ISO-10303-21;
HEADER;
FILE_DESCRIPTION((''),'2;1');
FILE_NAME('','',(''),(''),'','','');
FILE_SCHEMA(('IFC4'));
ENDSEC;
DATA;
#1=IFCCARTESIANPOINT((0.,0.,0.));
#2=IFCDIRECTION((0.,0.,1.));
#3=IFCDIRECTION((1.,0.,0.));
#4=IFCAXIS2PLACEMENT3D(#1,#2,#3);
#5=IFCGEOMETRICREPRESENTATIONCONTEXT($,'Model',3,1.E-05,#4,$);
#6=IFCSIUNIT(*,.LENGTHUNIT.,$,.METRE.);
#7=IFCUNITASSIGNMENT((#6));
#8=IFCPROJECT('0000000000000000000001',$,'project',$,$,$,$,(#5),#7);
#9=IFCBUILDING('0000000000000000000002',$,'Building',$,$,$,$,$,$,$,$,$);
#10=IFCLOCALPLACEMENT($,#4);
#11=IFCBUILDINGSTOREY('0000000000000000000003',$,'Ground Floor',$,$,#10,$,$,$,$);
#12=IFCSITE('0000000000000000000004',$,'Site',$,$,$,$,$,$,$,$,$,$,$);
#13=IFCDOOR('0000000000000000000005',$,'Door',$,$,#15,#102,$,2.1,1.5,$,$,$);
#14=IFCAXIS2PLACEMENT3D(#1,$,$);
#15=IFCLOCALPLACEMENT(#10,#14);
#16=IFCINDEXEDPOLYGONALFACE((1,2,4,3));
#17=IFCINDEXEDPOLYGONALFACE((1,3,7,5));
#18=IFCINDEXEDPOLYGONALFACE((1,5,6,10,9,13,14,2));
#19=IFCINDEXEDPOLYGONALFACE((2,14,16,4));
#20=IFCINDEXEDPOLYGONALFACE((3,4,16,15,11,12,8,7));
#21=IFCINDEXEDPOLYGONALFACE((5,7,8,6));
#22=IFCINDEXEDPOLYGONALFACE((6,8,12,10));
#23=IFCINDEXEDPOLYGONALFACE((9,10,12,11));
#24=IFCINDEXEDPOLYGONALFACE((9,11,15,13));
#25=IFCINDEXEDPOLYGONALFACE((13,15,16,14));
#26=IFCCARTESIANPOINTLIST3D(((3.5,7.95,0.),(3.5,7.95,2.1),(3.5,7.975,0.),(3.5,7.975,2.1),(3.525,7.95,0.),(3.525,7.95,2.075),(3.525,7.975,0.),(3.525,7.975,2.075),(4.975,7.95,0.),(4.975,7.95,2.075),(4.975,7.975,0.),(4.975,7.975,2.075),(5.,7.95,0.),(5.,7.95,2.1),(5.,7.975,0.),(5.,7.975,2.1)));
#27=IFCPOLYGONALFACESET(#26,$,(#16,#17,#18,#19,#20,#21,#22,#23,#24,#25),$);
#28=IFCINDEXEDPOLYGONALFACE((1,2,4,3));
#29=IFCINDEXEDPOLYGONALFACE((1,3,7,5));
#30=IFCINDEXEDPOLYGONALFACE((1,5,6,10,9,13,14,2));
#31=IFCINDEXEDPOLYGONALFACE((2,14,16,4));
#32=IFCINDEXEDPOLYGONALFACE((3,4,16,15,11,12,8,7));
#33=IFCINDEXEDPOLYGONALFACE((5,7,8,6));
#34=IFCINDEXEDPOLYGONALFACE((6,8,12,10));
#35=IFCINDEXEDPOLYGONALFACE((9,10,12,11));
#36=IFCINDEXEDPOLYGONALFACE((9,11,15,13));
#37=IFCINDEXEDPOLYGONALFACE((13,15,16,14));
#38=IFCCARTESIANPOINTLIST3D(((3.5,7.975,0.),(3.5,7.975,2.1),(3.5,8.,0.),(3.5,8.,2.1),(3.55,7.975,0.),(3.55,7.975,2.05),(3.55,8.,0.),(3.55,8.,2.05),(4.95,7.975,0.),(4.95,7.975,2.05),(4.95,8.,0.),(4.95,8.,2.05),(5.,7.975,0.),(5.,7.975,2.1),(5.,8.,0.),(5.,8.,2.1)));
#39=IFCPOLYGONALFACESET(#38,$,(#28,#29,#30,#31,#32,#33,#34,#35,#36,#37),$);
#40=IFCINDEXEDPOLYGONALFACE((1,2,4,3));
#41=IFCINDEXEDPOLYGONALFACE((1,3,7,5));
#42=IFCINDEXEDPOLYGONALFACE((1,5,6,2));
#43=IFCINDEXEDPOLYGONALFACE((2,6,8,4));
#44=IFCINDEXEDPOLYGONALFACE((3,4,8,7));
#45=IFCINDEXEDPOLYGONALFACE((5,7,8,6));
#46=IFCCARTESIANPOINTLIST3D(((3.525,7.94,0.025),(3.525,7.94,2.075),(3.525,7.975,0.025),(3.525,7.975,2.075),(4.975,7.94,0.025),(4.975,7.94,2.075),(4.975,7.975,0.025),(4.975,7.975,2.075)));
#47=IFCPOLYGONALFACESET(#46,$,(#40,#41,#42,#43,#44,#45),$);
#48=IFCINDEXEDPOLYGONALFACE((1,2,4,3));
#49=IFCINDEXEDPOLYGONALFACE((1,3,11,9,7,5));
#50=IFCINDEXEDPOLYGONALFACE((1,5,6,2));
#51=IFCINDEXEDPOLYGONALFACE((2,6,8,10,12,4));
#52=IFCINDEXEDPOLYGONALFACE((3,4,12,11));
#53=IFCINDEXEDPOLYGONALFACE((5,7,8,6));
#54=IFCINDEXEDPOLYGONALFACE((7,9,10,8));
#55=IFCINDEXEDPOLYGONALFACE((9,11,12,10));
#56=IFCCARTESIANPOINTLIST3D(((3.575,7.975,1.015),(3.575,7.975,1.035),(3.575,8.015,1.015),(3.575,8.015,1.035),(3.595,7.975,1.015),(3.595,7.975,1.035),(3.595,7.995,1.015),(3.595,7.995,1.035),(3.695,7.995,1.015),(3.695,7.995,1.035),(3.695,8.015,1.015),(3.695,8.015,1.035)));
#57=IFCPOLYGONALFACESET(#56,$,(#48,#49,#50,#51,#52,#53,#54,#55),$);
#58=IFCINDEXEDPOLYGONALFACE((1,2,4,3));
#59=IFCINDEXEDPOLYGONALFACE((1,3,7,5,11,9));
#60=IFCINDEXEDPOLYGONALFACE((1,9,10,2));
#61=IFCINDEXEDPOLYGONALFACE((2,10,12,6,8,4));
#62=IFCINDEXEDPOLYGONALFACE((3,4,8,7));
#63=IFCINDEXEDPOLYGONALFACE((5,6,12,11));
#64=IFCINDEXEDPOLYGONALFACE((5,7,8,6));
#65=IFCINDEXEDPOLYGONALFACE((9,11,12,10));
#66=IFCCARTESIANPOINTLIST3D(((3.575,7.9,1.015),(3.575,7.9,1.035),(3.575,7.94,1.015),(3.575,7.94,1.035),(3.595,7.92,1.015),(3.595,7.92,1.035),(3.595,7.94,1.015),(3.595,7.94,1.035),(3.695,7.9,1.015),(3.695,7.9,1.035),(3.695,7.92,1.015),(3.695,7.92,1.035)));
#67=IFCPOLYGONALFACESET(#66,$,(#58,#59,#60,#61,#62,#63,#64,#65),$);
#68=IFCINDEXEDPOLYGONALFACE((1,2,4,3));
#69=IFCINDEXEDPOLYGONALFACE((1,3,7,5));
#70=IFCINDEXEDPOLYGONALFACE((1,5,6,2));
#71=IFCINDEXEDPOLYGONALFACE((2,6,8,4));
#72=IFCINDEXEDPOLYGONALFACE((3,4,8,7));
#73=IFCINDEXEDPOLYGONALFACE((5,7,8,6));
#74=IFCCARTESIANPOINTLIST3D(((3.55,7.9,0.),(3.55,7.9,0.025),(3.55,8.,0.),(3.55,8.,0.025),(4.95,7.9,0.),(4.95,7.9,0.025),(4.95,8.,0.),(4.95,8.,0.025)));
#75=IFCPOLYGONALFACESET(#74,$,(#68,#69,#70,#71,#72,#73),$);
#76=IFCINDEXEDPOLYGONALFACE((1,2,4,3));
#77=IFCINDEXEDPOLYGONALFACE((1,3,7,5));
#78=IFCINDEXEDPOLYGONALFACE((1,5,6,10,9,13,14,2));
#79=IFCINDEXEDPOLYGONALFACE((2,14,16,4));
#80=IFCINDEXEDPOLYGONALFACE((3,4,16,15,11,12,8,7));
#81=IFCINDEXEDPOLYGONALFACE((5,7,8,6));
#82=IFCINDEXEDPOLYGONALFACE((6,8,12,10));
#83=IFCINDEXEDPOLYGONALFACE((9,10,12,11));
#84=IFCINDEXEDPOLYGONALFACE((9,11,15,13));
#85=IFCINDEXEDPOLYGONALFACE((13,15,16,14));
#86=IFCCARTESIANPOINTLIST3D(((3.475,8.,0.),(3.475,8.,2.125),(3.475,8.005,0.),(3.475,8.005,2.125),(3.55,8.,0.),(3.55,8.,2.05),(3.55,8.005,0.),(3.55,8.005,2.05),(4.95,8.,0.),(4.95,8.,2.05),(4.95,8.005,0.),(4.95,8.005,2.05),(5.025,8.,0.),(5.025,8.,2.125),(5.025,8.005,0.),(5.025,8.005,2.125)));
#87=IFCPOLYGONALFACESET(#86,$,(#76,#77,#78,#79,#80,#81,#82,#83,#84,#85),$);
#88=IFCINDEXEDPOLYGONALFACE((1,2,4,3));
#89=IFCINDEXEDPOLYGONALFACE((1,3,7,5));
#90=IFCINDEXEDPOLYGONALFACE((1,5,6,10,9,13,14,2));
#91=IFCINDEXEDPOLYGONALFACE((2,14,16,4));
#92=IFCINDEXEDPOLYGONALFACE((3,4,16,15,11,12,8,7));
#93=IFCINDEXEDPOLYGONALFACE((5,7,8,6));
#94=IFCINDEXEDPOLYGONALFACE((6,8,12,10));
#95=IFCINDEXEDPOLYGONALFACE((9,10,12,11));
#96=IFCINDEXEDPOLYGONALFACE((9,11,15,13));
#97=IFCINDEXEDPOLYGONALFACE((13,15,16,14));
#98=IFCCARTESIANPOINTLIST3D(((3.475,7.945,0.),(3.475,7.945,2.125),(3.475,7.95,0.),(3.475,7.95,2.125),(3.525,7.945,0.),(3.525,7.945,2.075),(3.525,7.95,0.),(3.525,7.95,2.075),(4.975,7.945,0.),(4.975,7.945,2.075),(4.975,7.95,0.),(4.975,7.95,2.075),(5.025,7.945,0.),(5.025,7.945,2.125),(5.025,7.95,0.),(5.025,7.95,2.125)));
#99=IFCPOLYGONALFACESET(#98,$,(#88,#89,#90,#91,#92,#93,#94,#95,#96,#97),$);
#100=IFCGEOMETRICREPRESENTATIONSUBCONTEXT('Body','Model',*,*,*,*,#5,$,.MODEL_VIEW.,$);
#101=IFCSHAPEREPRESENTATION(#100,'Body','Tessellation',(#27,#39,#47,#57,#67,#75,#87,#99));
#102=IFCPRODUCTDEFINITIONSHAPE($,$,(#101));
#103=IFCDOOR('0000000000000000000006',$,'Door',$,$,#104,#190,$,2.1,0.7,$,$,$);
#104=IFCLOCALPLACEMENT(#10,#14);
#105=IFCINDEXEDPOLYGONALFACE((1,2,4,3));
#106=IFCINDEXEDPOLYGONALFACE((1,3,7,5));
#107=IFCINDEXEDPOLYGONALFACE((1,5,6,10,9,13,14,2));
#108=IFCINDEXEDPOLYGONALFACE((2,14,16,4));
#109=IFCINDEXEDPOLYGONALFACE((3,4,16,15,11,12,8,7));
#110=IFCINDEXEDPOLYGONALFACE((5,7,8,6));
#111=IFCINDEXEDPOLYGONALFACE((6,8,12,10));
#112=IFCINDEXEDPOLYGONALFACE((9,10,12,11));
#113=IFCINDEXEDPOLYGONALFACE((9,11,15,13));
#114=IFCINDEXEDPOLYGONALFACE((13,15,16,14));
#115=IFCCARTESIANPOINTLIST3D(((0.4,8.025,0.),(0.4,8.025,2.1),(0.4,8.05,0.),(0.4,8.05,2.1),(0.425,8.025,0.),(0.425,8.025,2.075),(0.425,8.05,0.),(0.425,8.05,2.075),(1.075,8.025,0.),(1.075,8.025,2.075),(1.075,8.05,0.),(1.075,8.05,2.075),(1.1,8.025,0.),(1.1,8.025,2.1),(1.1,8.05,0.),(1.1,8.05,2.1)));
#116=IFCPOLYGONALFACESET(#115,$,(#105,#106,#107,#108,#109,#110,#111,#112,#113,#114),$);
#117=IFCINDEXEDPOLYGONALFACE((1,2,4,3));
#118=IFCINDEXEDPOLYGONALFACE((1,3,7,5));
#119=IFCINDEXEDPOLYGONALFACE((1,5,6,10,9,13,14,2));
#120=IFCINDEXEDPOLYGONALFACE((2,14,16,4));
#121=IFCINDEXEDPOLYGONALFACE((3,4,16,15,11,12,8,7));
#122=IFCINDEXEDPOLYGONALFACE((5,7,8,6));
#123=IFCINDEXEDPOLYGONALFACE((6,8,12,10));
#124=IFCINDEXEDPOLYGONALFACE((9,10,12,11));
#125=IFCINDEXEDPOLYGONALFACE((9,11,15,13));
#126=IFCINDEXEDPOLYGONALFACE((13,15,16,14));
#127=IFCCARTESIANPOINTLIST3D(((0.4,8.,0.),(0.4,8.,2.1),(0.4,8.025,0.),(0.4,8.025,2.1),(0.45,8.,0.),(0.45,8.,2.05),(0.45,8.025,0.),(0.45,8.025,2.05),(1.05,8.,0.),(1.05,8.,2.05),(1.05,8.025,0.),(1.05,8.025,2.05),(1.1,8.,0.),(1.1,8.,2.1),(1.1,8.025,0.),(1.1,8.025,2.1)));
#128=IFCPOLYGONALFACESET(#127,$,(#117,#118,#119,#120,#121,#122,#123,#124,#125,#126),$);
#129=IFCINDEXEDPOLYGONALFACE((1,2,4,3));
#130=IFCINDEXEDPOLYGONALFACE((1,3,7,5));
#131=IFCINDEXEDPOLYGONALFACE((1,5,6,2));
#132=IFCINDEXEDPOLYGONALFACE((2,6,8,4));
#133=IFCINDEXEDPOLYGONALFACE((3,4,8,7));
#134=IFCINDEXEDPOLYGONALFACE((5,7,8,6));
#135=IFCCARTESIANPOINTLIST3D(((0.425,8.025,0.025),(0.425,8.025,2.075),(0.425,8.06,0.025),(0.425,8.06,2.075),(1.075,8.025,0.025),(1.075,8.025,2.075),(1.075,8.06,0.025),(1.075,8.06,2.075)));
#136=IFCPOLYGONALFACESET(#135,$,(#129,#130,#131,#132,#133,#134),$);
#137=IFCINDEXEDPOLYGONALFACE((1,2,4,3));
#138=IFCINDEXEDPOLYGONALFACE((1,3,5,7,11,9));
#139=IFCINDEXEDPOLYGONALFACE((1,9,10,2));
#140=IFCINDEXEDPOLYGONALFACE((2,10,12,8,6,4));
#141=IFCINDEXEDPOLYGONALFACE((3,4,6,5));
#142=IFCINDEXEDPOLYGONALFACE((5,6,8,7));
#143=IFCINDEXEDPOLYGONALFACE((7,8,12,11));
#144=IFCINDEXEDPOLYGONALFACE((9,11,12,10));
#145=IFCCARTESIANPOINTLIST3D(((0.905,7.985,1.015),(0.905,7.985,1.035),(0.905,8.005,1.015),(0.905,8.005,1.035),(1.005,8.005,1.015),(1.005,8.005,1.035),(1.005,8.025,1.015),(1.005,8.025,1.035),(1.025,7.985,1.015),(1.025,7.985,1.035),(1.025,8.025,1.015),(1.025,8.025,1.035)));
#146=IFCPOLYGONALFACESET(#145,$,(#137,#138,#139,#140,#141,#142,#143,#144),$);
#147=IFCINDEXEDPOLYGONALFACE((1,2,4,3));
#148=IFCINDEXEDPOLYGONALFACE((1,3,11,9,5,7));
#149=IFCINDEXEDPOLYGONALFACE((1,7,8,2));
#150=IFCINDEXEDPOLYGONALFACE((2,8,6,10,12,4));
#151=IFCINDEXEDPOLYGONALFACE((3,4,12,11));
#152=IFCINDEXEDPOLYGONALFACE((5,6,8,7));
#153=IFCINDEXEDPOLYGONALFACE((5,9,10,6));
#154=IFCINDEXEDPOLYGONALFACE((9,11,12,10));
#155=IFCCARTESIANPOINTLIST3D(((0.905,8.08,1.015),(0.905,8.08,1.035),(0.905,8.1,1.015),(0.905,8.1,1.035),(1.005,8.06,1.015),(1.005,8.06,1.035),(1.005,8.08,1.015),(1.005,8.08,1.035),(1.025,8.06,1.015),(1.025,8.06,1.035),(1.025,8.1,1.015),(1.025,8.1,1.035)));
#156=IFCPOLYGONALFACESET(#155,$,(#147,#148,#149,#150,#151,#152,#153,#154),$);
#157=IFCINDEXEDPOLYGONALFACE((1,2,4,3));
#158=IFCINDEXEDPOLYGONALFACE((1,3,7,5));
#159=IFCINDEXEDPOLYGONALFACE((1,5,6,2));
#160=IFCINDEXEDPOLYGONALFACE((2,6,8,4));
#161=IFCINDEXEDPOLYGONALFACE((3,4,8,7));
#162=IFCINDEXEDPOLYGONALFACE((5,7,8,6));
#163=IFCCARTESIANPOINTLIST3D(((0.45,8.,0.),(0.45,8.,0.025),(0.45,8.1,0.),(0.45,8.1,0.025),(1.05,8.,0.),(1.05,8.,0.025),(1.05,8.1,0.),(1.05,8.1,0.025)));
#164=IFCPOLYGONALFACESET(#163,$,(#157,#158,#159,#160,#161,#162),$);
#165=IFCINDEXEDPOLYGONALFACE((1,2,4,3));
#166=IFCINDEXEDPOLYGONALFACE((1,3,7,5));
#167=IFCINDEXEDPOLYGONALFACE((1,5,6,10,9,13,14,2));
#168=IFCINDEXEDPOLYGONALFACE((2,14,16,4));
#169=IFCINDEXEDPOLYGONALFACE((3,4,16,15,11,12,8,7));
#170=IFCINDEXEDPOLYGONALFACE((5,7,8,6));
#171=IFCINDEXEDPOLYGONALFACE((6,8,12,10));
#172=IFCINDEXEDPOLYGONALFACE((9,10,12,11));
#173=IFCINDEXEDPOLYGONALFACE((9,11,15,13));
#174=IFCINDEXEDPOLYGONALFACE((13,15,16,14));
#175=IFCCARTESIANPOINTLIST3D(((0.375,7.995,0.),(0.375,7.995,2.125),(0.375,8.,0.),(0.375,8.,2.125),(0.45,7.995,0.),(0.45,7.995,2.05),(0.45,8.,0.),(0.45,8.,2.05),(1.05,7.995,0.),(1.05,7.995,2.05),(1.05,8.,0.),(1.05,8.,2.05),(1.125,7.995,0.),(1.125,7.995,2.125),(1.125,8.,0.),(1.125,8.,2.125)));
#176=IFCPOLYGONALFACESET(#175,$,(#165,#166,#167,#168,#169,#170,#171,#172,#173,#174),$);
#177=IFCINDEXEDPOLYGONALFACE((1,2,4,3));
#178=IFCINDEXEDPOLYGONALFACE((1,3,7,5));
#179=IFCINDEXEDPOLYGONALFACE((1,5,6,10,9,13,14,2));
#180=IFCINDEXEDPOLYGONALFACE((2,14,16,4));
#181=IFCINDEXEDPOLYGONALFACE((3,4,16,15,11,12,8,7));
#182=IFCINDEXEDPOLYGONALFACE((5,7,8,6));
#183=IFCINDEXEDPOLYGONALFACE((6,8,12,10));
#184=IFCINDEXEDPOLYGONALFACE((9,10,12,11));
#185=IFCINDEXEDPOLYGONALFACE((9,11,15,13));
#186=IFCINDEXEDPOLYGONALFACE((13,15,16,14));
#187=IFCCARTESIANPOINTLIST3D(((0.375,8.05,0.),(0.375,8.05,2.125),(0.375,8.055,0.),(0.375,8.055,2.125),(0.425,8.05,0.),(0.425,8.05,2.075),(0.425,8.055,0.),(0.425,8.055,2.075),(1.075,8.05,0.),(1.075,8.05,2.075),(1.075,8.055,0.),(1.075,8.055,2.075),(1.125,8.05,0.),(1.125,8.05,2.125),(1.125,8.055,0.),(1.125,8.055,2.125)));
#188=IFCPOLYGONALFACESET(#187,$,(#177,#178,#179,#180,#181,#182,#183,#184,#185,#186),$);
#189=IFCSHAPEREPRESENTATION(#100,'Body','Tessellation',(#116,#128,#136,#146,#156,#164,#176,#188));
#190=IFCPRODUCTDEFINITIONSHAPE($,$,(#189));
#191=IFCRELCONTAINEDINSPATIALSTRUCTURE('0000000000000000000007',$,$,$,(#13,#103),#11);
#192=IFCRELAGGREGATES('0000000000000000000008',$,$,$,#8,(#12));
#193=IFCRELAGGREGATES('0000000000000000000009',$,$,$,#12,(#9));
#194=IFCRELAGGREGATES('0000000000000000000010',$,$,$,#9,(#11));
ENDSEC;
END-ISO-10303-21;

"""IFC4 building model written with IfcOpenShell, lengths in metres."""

from ifc_helpers import new_model, si_unit, frame, origin_with_axes, place, context, subcontext, project, spatial, line, indexed_curve, outline, extrude, element, save


model = new_model("IFC4")

# Units and contexts
model_context = context("Model", 3, precision=1e-05, world=origin_with_axes())
body_context = subcontext(model_context, "Body", "Model", "MODEL_VIEW")
ifc_project = project(units=[si_unit("LENGTHUNIT", "METRE")], contexts=[model_context])

# Site, building, storey
site = spatial("IfcSite", under=ifc_project, Name="Site")
building = spatial("IfcBuilding", under=site, Name="Building")
storey_placement = place(None, origin_with_axes())
storey = spatial("IfcBuildingStorey", under=building, at=storey_placement, Name="Ground Floor")

# Doors
door_1_placement = place(storey_placement, frame((5.0, 8.0, 0.0), z_axis=(0.0, 0.0, 1.0), x_axis=(-1.0, 0.0, 0.0)))
element("IfcDoor", 1, at=door_1_placement, inside=storey, Name="Door", OverallHeight=2.1, OverallWidth=1.5, context=body_context, shape_type="SweptSolid", body=[
    extrude(outline(indexed_curve([(0.0, 0.0), (0.0, 2.1), (1.5, 2.1), (1.5, 0.0), (1.475, 0.0), (1.475, 2.075), (0.025, 2.075), (0.025, 0.0)], segments=[line(1, 2, 3, 4, 5, 6, 7, 8, 1)])), frame((0.0, 0.025, 0.0), z_axis=(0.0, -1.0, 0.0), x_axis=(1.0, 0.0, 0.0)), (0.0, 0.0, -1.0), 0.025),
    extrude(outline(indexed_curve([(0.0, 0.0), (0.0, 2.1), (1.5, 2.1), (1.5, 0.0), (1.45, 0.0), (1.45, 2.05), (0.05, 2.05), (0.05, 0.0)], segments=[line(1, 2, 3, 4, 5, 6, 7, 8, 1)])), frame((0.0, 0.0, 0.0), z_axis=(0.0, -1.0, 0.0), x_axis=(1.0, 0.0, 0.0)), (0.0, 0.0, -1.0), 0.025),
    extrude(outline(indexed_curve([(0.0, 0.0), (1.45, 0.0), (1.45, 0.035), (0.0, 0.035)], segments=[line(1, 2, 3, 4, 1)])), frame((0.025, 0.025, 0.025), z_axis=(0.0, 0.0, 1.0), x_axis=(1.0, 0.0, 0.0)), (0.0, 0.0, 1.0), 2.05),
    extrude(outline(indexed_curve([(0.0, 0.0), (0.0, -0.04), (-0.12, -0.04), (-0.12, -0.02), (-0.02, -0.02), (-0.02, 0.0)], segments=[line(1, 2, 3, 4, 5, 6, 1)])), frame((1.425, 0.025, 1.015), z_axis=(0.0, 0.0, 1.0), x_axis=(1.0, 0.0, 0.0)), (0.0, 0.0, 1.0), 0.02),
    extrude(outline(indexed_curve([(0.0, 0.0), (0.0, 0.04), (-0.12, 0.04), (-0.12, 0.02), (-0.02, 0.02), (-0.02, 0.0)], segments=[line(1, 2, 3, 4, 5, 6, 1)])), frame((1.425, 0.06, 1.015), z_axis=(0.0, 0.0, 1.0), x_axis=(1.0, 0.0, 0.0)), (0.0, 0.0, 1.0), 0.02),
    extrude(outline(indexed_curve([(0.0, 0.0), (1.4, 0.0), (1.4, 0.1), (0.0, 0.1)], segments=[line(1, 2, 3, 4, 1)])), frame((0.05, 0.0, 0.0), z_axis=(0.0, 0.0, 1.0), x_axis=(1.0, 0.0, 0.0)), (0.0, 0.0, 1.0), 0.025),
    extrude(outline(indexed_curve([(0.0, 0.0), (0.0, 2.125), (1.55, 2.125), (1.55, 0.0), (1.475, 0.0), (1.475, 2.05), (0.075, 2.05), (0.075, 0.0)], segments=[line(1, 2, 3, 4, 5, 6, 7, 8, 1)])), frame((-0.025, -0.005, 0.0), z_axis=(0.0, -1.0, 0.0), x_axis=(1.0, 0.0, 0.0)), (0.0, 0.0, -1.0), 0.005),
    extrude(outline(indexed_curve([(0.0, 0.0), (0.0, 2.125), (1.55, 2.125), (1.55, 0.0), (1.5, 0.0), (1.5, 2.075), (0.05, 2.075), (0.05, 0.0)], segments=[line(1, 2, 3, 4, 5, 6, 7, 8, 1)])), frame((-0.025, 0.05, 0.0), z_axis=(0.0, -1.0, 0.0), x_axis=(1.0, 0.0, 0.0)), (0.0, 0.0, -1.0), 0.005),
])
door_2_placement = place(storey_placement, frame((0.4, 8.0, 0.0), z_axis=(0.0, 0.0, 1.0), x_axis=(1.0, 0.0, 0.0)))
element("IfcDoor", 2, at=door_2_placement, inside=storey, Name="Door", OverallHeight=2.1, OverallWidth=0.7, context=body_context, shape_type="SweptSolid", body=[
    extrude(outline(indexed_curve([(0.0, 0.0), (0.0, 2.1), (0.7, 2.1), (0.7, 0.0), (0.675, 0.0), (0.675, 2.075), (0.025, 2.075), (0.025, 0.0)], segments=[line(1, 2, 3, 4, 5, 6, 7, 8, 1)])), frame((0.0, 0.025, 0.0), z_axis=(0.0, -1.0, 0.0), x_axis=(1.0, 0.0, 0.0)), (0.0, 0.0, -1.0), 0.025),
    extrude(outline(indexed_curve([(0.0, 0.0), (0.0, 2.1), (0.7, 2.1), (0.7, 0.0), (0.65, 0.0), (0.65, 2.05), (0.05, 2.05), (0.05, 0.0)], segments=[line(1, 2, 3, 4, 5, 6, 7, 8, 1)])), frame((0.0, 0.0, 0.0), z_axis=(0.0, -1.0, 0.0), x_axis=(1.0, 0.0, 0.0)), (0.0, 0.0, -1.0), 0.025),
    extrude(outline(indexed_curve([(0.0, 0.0), (0.65, 0.0), (0.65, 0.035), (0.0, 0.035)], segments=[line(1, 2, 3, 4, 1)])), frame((0.025, 0.025, 0.025), z_axis=(0.0, 0.0, 1.0), x_axis=(1.0, 0.0, 0.0)), (0.0, 0.0, 1.0), 2.05),
    extrude(outline(indexed_curve([(0.0, 0.0), (0.0, -0.04), (-0.12, -0.04), (-0.12, -0.02), (-0.02, -0.02), (-0.02, 0.0)], segments=[line(1, 2, 3, 4, 5, 6, 1)])), frame((0.625, 0.025, 1.015), z_axis=(0.0, 0.0, 1.0), x_axis=(1.0, 0.0, 0.0)), (0.0, 0.0, 1.0), 0.02),
    extrude(outline(indexed_curve([(0.0, 0.0), (0.0, 0.04), (-0.12, 0.04), (-0.12, 0.02), (-0.02, 0.02), (-0.02, 0.0)], segments=[line(1, 2, 3, 4, 5, 6, 1)])), frame((0.625, 0.06, 1.015), z_axis=(0.0, 0.0, 1.0), x_axis=(1.0, 0.0, 0.0)), (0.0, 0.0, 1.0), 0.02),
    extrude(outline(indexed_curve([(0.0, 0.0), (0.6, 0.0), (0.6, 0.1), (0.0, 0.1)], segments=[line(1, 2, 3, 4, 1)])), frame((0.05, 0.0, 0.0), z_axis=(0.0, 0.0, 1.0), x_axis=(1.0, 0.0, 0.0)), (0.0, 0.0, 1.0), 0.025),
    extrude(outline(indexed_curve([(0.0, 0.0), (0.0, 2.125), (0.75, 2.125), (0.75, 0.0), (0.675, 0.0), (0.675, 2.05), (0.075, 2.05), (0.075, 0.0)], segments=[line(1, 2, 3, 4, 5, 6, 7, 8, 1)])), frame((-0.025, -0.005, 0.0), z_axis=(0.0, -1.0, 0.0), x_axis=(1.0, 0.0, 0.0)), (0.0, 0.0, -1.0), 0.005),
    extrude(outline(indexed_curve([(0.0, 0.0), (0.0, 2.125), (0.75, 2.125), (0.75, 0.0), (0.7, 0.0), (0.7, 2.075), (0.05, 2.075), (0.05, 0.0)], segments=[line(1, 2, 3, 4, 5, 6, 7, 8, 1)])), frame((-0.025, 0.05, 0.0), z_axis=(0.0, -1.0, 0.0), x_axis=(1.0, 0.0, 0.0)), (0.0, 0.0, -1.0), 0.005),
])

save(model, "model.ifc")
